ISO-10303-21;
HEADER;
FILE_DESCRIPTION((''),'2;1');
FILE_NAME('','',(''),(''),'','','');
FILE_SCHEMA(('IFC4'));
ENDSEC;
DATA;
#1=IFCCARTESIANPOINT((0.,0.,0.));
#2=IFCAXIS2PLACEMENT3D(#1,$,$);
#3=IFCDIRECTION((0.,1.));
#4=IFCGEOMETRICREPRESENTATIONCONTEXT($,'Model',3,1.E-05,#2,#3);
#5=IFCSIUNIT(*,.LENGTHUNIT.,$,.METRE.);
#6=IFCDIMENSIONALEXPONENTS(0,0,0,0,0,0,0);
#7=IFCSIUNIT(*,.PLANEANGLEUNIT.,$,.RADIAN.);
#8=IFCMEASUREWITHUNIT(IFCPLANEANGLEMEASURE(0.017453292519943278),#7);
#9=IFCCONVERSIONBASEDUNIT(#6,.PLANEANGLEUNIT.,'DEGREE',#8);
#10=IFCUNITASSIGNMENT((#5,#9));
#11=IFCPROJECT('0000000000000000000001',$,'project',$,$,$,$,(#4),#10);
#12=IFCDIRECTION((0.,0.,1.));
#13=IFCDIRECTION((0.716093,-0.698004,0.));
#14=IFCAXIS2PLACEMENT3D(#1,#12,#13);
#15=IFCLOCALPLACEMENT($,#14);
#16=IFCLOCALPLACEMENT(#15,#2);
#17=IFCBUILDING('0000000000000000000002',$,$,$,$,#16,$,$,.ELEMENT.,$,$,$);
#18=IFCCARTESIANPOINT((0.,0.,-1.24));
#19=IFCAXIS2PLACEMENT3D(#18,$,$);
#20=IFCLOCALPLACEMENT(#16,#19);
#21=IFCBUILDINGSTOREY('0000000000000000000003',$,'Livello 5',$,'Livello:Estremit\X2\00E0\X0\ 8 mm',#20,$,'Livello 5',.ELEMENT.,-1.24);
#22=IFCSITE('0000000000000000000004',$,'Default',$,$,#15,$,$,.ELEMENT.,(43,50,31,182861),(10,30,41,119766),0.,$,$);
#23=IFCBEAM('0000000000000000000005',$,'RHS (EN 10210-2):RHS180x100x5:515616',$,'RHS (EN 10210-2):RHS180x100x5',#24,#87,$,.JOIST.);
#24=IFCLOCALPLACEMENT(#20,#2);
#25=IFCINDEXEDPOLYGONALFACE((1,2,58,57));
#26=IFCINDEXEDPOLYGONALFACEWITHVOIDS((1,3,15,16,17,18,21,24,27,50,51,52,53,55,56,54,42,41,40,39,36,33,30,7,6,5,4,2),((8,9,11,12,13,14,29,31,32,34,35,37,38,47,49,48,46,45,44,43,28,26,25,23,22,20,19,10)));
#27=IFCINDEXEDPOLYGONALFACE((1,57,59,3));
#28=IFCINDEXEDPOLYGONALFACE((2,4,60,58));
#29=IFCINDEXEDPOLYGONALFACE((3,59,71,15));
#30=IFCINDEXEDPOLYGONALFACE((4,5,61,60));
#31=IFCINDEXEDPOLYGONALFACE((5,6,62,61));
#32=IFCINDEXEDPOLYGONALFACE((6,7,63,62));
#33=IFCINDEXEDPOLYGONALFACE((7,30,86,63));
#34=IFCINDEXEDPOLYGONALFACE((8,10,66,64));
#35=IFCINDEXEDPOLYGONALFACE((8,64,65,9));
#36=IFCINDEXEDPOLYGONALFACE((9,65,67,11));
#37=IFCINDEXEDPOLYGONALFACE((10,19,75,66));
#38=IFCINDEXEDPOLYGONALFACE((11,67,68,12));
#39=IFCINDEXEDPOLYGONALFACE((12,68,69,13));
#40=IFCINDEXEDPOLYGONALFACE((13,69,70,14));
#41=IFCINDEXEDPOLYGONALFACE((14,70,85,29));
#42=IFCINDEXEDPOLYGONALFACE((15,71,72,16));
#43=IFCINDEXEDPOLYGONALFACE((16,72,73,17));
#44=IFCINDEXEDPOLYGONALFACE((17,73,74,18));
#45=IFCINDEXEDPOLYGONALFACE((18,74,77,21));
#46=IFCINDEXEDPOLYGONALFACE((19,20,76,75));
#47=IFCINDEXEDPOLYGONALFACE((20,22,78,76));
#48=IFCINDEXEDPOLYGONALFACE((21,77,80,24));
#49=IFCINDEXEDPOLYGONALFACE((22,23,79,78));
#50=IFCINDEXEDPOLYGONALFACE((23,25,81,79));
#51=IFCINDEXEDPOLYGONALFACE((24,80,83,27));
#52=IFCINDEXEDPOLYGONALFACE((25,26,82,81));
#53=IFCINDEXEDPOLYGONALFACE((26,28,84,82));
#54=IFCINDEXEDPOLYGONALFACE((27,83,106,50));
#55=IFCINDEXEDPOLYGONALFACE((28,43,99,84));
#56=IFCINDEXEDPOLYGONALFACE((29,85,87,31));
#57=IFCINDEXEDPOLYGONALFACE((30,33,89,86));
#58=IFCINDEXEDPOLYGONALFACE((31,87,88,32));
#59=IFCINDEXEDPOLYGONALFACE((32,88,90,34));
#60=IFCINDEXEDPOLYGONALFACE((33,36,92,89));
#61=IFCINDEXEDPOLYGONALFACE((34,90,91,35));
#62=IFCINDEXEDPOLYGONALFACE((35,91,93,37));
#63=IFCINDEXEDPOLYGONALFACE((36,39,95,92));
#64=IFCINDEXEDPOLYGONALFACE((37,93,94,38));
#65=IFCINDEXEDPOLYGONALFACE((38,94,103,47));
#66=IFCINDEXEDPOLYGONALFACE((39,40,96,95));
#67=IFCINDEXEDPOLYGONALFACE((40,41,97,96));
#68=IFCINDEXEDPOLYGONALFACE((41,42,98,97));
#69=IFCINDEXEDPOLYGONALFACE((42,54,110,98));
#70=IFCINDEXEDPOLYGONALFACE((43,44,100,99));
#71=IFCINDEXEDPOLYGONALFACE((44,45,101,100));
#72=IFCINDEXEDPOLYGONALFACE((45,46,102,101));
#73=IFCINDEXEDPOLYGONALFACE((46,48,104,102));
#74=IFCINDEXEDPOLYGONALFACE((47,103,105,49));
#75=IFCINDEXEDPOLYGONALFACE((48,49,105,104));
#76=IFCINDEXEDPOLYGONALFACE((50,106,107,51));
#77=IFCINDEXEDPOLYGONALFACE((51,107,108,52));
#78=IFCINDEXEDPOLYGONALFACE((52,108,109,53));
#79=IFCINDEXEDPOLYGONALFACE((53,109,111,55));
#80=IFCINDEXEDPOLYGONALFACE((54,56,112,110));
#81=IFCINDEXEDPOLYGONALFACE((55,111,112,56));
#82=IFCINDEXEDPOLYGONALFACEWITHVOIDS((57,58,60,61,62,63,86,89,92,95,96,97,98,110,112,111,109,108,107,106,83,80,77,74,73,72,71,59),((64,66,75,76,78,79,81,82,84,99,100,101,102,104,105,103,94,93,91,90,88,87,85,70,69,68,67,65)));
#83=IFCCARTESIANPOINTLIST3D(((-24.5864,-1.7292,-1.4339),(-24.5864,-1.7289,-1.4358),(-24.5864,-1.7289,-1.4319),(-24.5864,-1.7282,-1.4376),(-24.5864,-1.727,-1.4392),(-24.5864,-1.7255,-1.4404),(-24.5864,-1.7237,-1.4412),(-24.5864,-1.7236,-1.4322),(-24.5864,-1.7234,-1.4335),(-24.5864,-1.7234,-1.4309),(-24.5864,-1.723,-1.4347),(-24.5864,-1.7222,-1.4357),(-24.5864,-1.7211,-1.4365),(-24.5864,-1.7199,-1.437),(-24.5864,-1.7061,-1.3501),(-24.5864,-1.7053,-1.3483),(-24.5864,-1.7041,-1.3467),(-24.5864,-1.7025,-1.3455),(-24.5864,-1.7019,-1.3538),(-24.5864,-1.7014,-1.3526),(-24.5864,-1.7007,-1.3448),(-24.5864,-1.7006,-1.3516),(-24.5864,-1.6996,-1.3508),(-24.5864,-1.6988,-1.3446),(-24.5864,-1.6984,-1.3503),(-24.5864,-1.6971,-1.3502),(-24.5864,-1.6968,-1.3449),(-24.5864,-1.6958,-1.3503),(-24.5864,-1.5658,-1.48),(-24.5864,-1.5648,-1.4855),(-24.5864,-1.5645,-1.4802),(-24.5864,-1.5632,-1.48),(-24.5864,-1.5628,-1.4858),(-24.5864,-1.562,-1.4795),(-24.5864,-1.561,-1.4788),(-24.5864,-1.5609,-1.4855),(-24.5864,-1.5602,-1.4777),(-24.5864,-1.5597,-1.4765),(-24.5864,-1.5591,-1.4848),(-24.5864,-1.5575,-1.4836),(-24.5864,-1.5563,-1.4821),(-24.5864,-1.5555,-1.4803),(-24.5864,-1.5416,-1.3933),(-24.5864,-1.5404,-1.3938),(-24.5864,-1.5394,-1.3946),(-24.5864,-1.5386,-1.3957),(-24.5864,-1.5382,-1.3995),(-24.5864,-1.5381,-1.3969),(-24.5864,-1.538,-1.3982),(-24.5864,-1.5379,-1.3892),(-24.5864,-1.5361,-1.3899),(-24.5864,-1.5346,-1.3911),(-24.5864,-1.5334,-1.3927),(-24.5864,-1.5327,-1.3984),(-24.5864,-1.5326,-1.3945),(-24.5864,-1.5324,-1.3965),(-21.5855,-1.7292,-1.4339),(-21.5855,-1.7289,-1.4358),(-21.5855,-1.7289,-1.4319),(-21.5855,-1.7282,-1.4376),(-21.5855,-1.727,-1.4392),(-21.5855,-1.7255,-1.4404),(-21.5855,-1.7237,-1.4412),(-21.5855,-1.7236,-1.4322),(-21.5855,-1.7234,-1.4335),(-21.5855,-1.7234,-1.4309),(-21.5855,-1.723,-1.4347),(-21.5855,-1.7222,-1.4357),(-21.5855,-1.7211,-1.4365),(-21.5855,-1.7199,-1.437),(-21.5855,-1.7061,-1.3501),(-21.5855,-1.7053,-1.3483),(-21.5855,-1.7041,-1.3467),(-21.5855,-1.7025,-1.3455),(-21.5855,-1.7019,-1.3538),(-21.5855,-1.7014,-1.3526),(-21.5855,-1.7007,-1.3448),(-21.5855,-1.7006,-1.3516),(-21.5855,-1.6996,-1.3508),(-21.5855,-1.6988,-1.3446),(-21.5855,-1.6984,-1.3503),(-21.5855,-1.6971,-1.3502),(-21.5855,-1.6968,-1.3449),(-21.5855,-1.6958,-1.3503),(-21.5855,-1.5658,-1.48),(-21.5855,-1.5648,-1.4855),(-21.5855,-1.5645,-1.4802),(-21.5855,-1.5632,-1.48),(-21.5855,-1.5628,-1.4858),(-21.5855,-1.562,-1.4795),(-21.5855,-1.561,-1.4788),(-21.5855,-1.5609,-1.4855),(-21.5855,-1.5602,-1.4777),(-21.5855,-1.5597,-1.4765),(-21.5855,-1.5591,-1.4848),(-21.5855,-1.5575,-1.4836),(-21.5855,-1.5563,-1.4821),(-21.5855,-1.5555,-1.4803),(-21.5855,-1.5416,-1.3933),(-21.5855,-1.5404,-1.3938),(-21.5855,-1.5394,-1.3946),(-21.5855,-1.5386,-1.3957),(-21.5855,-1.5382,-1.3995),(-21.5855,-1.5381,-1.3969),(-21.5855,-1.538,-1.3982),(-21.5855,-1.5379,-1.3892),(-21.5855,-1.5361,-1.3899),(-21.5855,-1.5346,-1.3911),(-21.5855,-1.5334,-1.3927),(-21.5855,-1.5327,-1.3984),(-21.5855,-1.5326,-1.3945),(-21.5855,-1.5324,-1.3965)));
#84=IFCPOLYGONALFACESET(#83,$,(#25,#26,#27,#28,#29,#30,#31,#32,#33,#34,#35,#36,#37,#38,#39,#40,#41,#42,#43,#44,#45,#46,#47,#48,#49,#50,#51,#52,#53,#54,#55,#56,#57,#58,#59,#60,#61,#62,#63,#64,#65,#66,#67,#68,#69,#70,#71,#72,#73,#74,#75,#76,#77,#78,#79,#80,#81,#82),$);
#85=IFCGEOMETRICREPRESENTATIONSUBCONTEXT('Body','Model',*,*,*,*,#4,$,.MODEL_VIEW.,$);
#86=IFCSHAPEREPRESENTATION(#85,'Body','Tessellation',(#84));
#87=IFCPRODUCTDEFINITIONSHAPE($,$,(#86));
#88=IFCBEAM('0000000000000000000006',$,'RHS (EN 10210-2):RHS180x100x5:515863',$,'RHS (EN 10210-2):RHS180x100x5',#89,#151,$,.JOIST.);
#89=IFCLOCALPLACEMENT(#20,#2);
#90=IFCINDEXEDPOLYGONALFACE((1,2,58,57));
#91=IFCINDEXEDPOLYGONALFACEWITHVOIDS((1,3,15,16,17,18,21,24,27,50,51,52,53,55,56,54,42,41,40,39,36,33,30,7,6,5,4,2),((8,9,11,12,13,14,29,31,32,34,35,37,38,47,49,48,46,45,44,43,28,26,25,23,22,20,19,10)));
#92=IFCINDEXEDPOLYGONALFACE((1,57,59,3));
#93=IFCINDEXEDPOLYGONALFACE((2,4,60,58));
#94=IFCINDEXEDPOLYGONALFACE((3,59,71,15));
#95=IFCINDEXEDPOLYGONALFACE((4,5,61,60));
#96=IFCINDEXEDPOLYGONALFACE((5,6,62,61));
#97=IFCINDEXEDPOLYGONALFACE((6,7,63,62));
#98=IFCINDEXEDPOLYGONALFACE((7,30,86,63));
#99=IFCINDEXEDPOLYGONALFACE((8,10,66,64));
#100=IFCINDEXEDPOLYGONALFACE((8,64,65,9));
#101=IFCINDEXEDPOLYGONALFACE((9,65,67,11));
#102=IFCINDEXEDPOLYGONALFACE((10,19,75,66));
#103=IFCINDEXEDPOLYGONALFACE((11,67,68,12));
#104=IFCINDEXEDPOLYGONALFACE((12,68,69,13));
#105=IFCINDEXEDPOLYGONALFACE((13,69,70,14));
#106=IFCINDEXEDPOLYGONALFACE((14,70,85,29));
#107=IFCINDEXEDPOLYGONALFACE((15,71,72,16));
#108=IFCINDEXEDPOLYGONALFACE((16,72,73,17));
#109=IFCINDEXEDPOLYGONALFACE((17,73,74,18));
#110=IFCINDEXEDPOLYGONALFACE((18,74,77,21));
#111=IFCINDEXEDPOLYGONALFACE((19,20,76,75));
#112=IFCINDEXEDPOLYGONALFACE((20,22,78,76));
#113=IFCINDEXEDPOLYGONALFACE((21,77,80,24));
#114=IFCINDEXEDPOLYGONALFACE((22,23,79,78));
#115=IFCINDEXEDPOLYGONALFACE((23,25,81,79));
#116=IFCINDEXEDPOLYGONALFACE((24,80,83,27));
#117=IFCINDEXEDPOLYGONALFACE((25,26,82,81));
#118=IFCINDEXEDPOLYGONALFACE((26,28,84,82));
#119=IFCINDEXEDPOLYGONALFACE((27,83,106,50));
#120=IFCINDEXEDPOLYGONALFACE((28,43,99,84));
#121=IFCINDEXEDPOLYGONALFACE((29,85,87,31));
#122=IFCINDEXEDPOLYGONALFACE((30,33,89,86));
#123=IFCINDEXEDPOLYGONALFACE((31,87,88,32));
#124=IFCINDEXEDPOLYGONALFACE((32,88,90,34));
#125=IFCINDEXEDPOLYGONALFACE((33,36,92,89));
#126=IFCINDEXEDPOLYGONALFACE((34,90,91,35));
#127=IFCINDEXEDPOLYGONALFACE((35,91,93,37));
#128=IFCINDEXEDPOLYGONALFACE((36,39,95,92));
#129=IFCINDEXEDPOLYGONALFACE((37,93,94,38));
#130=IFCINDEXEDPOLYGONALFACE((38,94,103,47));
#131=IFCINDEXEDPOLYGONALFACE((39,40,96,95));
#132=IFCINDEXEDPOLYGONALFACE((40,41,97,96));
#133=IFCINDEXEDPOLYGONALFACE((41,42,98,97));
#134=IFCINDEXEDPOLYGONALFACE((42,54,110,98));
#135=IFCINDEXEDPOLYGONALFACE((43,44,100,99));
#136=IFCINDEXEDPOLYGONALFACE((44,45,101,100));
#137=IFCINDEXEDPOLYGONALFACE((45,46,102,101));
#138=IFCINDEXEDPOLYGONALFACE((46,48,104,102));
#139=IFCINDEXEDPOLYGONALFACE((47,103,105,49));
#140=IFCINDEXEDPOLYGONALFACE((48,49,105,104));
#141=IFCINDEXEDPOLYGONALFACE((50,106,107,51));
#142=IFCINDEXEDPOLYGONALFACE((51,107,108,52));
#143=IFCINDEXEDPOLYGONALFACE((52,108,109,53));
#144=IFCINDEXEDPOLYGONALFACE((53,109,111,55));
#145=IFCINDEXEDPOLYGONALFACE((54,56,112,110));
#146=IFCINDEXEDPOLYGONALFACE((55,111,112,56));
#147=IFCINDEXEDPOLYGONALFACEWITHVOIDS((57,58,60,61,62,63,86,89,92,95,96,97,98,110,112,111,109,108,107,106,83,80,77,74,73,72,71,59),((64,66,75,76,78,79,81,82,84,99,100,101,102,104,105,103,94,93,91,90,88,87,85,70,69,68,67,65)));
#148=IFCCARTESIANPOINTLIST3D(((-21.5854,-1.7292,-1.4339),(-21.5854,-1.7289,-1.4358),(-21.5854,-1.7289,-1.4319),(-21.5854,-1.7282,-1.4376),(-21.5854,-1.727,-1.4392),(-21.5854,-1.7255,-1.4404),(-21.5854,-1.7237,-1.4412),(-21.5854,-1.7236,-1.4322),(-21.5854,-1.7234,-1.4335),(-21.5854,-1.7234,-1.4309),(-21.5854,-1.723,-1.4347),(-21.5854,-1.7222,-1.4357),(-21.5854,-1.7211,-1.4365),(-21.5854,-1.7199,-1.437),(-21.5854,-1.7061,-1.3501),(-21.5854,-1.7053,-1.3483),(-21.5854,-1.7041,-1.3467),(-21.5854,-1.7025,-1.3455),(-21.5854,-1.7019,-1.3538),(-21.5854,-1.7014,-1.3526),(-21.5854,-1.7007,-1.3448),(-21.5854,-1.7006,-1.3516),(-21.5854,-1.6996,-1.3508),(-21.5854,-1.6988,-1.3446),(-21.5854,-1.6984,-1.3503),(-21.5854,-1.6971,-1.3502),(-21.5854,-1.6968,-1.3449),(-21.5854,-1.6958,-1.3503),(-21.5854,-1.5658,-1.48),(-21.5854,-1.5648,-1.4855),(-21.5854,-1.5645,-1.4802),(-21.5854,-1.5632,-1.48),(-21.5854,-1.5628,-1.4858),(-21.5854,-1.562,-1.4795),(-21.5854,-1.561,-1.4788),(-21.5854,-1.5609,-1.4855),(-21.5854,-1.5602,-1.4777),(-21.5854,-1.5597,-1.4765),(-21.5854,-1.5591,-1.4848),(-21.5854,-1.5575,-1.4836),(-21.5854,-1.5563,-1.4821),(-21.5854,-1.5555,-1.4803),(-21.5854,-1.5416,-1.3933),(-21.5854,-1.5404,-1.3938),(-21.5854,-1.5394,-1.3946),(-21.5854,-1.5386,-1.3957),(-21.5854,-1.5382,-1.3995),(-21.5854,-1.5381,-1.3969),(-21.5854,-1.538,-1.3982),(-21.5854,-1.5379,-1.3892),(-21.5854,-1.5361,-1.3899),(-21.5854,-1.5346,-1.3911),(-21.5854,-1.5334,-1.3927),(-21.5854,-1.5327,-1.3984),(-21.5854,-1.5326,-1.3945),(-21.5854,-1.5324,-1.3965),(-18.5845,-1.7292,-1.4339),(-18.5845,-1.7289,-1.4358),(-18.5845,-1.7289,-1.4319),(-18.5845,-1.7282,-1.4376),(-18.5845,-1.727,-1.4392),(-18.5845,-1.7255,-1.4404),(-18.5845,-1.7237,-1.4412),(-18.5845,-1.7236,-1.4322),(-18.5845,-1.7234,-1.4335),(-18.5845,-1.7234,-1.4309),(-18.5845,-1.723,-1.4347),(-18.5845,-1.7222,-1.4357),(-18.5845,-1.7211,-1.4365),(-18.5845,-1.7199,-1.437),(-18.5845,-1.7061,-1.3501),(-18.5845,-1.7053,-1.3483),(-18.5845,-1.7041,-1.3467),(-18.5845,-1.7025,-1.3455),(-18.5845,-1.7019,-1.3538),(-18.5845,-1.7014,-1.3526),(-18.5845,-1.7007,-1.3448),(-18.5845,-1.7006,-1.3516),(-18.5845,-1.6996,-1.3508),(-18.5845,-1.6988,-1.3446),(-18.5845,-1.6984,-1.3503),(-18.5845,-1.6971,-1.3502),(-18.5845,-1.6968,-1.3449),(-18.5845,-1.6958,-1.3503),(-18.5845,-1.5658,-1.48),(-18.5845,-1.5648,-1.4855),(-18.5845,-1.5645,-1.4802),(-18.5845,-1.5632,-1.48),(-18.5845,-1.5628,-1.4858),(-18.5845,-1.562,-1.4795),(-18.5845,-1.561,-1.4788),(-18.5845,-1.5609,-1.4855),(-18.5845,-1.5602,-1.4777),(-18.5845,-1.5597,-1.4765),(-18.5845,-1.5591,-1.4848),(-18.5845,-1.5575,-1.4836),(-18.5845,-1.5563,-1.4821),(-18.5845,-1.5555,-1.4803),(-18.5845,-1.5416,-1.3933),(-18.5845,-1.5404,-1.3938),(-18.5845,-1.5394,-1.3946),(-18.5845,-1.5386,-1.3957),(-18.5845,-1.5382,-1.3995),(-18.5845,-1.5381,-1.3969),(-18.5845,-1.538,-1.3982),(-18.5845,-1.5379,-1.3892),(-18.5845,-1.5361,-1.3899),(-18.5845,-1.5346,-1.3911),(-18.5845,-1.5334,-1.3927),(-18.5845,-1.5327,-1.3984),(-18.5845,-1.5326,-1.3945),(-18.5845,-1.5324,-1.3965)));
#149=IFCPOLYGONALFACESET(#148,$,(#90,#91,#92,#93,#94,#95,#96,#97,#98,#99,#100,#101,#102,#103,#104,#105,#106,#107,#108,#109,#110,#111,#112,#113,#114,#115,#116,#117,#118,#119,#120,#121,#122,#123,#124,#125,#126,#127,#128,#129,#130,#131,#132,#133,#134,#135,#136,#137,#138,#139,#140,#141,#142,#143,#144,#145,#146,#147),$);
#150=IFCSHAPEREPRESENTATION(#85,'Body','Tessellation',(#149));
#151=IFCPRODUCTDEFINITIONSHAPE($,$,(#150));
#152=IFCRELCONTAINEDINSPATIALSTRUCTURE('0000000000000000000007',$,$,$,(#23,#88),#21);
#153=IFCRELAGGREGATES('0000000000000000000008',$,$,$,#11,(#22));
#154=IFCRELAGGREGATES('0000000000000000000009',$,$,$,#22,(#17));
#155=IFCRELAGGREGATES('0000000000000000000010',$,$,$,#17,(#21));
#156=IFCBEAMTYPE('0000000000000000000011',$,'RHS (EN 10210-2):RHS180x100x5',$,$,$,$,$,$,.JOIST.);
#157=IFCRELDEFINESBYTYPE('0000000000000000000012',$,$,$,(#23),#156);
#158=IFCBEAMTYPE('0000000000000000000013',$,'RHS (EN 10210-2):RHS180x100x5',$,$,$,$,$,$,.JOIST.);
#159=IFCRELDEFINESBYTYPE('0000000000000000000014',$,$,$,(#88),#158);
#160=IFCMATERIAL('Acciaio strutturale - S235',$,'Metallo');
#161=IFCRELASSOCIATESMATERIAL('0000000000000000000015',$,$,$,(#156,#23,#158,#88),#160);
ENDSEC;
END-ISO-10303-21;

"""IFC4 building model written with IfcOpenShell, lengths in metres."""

from ifc_helpers import new_model, entity, si_unit, converted_unit, direction, frame, origin, place, context, subcontext, project, spatial, line, arc, indexed_curve, outline, extrude, source, transform, mapped, material, type_object, type_shapes, element, save


model = new_model("IFC4")

# Units and contexts
model_context = context("Model", 3, precision=1e-05, world=origin(), true_north=direction((0.0, 1.0)))
body_context = subcontext(model_context, "Body", "Model", "MODEL_VIEW")
ifc_project = project(units=[si_unit("LENGTHUNIT", "METRE"), converted_unit("PLANEANGLEUNIT", "DEGREE", entity("IfcPlaneAngleMeasure", 0.017453292519943278), si_unit("PLANEANGLEUNIT", "RADIAN"), dimensions=[0, 0, 0, 0, 0, 0, 0])], contexts=[model_context])

# Site, building, storey
site_placement = place(None, frame((0.0, 0.0, 0.0), z_axis=(0.0, 0.0, 1.0), x_axis=(0.716093, -0.698004, 0.0)))
site = spatial("IfcSite", under=ifc_project, at=site_placement, Name="Default", CompositionType="ELEMENT", RefLatitude=(43, 50, 31, 182861), RefLongitude=(10, 30, 41, 119766), RefElevation=0.0)
building_placement = place(site_placement, origin())
building = spatial("IfcBuilding", under=site, at=building_placement, CompositionType="ELEMENT")
storey_placement = place(building_placement, frame((0.0, 0.0, -1.24)))
storey = spatial("IfcBuildingStorey", under=building, at=storey_placement, Name="Livello 5", ObjectType="Livello:Estremità 8 mm", LongName="Livello 5", CompositionType="ELEMENT", Elevation=-1.24)

# Beams
ifc_material = material(Name="Acciaio strutturale - S235", Category="Metallo")
beam_type_1 = type_object("IfcBeamType", Name="RHS (EN 10210-2):RHS180x100x5", PredefinedType="JOIST", material=ifc_material)
shared_shape_1 = source(origin(), body_context, "Body", "SweptSolid", [
    extrude(outline(indexed_curve([(-0.05, -0.0825), (-0.0478, -0.0878), (-0.0425, -0.09), (0.0425, -0.09), (0.0478, -0.0878), (0.05, -0.0825), (0.05, 0.0825), (0.0478, 0.0878), (0.0425, 0.09), (-0.0425, 0.09), (-0.0478, 0.0878), (-0.05, 0.0825)], segments=[arc(1, 2, 3), line(3, 4), arc(4, 5, 6), line(6, 7), arc(7, 8, 9), line(9, 10), arc(10, 11, 12), line(12, 1)], self_intersect=False), holes=[indexed_curve([(0.04, -0.085), (-0.04, -0.085), (-0.0435, -0.0835), (-0.045, -0.08), (-0.045, 0.08), (-0.0435, 0.0835), (-0.04, 0.085), (0.04, 0.085), (0.0435, 0.0835), (0.045, 0.08), (0.045, -0.08), (0.0435, -0.0835)], segments=[line(1, 2), arc(2, 3, 4), line(4, 5), arc(5, 6, 7), line(7, 8), arc(8, 9, 10), line(10, 11), arc(11, 12, 1)], self_intersect=False)]), frame((-1.5005, 0.0, 0.0), z_axis=(1.0, 0.0, 0.0), x_axis=(0.0, -1.0, 0.0)), (0.0, 0.0, 1.0), 3.0009),
])
type_shapes(beam_type_1, [shared_shape_1])
beam_1_placement = place(storey_placement, frame((-23.0859, -1.6308, -1.4152), z_axis=(0.0, 0.963256, -0.268584), x_axis=(-1.0, 0.0, 0.0)))
element("IfcBeam", 1, at=beam_1_placement, inside=storey, type_object=beam_type_1, material=ifc_material, Name="RHS (EN 10210-2):RHS180x100x5:515616", ObjectType="RHS (EN 10210-2):RHS180x100x5", PredefinedType="JOIST", context=body_context, shape_type="MappedRepresentation", body=[
    mapped(shared_shape_1, transform((0.0, 0.0, 0.0), scale=1.0)),
])
beam_type_2 = type_object("IfcBeamType", Name="RHS (EN 10210-2):RHS180x100x5", PredefinedType="JOIST", material=ifc_material)
shared_shape_2 = source(origin(), body_context, "Body", "SweptSolid", [
    extrude(outline(indexed_curve([(-0.05, -0.0825), (-0.0478, -0.0878), (-0.0425, -0.09), (0.0425, -0.09), (0.0478, -0.0878), (0.05, -0.0825), (0.05, 0.0825), (0.0478, 0.0878), (0.0425, 0.09), (-0.0425, 0.09), (-0.0478, 0.0878), (-0.05, 0.0825)], segments=[arc(1, 2, 3), line(3, 4), arc(4, 5, 6), line(6, 7), arc(7, 8, 9), line(9, 10), arc(10, 11, 12), line(12, 1)], self_intersect=False), holes=[indexed_curve([(0.04, -0.085), (-0.04, -0.085), (-0.0435, -0.0835), (-0.045, -0.08), (-0.045, 0.08), (-0.0435, 0.0835), (-0.04, 0.085), (0.04, 0.085), (0.0435, 0.0835), (0.045, 0.08), (0.045, -0.08), (0.0435, -0.0835)], segments=[line(1, 2), arc(2, 3, 4), line(4, 5), arc(5, 6, 7), line(7, 8), arc(8, 9, 10), line(10, 11), arc(11, 12, 1)], self_intersect=False)]), frame((-1.5005, 0.0, 0.0), z_axis=(1.0, 0.0, 0.0), x_axis=(0.0, -1.0, 0.0)), (0.0, 0.0, 1.0), 3.0009),
])
type_shapes(beam_type_2, [shared_shape_2])
for number, where, z_axis, x_axis, name in (
    (2, (-20.0849, -1.6308, -1.4152), (0.0, 0.963256, -0.268584), (-1.0, 0.0, 0.0), "RHS (EN 10210-2):RHS180x100x5:515863"),
):
    element("IfcBeam", number, at=place(storey_placement, frame(where, z_axis=z_axis, x_axis=x_axis)), inside=storey, type_object=beam_type_2, material=ifc_material, Name=name, ObjectType="RHS (EN 10210-2):RHS180x100x5", PredefinedType="JOIST", context=body_context, shape_type="MappedRepresentation", body=[
        mapped(shared_shape_2, transform((0.0, 0.0, 0.0), scale=1.0)),
    ])

save(model, "model.ifc")
